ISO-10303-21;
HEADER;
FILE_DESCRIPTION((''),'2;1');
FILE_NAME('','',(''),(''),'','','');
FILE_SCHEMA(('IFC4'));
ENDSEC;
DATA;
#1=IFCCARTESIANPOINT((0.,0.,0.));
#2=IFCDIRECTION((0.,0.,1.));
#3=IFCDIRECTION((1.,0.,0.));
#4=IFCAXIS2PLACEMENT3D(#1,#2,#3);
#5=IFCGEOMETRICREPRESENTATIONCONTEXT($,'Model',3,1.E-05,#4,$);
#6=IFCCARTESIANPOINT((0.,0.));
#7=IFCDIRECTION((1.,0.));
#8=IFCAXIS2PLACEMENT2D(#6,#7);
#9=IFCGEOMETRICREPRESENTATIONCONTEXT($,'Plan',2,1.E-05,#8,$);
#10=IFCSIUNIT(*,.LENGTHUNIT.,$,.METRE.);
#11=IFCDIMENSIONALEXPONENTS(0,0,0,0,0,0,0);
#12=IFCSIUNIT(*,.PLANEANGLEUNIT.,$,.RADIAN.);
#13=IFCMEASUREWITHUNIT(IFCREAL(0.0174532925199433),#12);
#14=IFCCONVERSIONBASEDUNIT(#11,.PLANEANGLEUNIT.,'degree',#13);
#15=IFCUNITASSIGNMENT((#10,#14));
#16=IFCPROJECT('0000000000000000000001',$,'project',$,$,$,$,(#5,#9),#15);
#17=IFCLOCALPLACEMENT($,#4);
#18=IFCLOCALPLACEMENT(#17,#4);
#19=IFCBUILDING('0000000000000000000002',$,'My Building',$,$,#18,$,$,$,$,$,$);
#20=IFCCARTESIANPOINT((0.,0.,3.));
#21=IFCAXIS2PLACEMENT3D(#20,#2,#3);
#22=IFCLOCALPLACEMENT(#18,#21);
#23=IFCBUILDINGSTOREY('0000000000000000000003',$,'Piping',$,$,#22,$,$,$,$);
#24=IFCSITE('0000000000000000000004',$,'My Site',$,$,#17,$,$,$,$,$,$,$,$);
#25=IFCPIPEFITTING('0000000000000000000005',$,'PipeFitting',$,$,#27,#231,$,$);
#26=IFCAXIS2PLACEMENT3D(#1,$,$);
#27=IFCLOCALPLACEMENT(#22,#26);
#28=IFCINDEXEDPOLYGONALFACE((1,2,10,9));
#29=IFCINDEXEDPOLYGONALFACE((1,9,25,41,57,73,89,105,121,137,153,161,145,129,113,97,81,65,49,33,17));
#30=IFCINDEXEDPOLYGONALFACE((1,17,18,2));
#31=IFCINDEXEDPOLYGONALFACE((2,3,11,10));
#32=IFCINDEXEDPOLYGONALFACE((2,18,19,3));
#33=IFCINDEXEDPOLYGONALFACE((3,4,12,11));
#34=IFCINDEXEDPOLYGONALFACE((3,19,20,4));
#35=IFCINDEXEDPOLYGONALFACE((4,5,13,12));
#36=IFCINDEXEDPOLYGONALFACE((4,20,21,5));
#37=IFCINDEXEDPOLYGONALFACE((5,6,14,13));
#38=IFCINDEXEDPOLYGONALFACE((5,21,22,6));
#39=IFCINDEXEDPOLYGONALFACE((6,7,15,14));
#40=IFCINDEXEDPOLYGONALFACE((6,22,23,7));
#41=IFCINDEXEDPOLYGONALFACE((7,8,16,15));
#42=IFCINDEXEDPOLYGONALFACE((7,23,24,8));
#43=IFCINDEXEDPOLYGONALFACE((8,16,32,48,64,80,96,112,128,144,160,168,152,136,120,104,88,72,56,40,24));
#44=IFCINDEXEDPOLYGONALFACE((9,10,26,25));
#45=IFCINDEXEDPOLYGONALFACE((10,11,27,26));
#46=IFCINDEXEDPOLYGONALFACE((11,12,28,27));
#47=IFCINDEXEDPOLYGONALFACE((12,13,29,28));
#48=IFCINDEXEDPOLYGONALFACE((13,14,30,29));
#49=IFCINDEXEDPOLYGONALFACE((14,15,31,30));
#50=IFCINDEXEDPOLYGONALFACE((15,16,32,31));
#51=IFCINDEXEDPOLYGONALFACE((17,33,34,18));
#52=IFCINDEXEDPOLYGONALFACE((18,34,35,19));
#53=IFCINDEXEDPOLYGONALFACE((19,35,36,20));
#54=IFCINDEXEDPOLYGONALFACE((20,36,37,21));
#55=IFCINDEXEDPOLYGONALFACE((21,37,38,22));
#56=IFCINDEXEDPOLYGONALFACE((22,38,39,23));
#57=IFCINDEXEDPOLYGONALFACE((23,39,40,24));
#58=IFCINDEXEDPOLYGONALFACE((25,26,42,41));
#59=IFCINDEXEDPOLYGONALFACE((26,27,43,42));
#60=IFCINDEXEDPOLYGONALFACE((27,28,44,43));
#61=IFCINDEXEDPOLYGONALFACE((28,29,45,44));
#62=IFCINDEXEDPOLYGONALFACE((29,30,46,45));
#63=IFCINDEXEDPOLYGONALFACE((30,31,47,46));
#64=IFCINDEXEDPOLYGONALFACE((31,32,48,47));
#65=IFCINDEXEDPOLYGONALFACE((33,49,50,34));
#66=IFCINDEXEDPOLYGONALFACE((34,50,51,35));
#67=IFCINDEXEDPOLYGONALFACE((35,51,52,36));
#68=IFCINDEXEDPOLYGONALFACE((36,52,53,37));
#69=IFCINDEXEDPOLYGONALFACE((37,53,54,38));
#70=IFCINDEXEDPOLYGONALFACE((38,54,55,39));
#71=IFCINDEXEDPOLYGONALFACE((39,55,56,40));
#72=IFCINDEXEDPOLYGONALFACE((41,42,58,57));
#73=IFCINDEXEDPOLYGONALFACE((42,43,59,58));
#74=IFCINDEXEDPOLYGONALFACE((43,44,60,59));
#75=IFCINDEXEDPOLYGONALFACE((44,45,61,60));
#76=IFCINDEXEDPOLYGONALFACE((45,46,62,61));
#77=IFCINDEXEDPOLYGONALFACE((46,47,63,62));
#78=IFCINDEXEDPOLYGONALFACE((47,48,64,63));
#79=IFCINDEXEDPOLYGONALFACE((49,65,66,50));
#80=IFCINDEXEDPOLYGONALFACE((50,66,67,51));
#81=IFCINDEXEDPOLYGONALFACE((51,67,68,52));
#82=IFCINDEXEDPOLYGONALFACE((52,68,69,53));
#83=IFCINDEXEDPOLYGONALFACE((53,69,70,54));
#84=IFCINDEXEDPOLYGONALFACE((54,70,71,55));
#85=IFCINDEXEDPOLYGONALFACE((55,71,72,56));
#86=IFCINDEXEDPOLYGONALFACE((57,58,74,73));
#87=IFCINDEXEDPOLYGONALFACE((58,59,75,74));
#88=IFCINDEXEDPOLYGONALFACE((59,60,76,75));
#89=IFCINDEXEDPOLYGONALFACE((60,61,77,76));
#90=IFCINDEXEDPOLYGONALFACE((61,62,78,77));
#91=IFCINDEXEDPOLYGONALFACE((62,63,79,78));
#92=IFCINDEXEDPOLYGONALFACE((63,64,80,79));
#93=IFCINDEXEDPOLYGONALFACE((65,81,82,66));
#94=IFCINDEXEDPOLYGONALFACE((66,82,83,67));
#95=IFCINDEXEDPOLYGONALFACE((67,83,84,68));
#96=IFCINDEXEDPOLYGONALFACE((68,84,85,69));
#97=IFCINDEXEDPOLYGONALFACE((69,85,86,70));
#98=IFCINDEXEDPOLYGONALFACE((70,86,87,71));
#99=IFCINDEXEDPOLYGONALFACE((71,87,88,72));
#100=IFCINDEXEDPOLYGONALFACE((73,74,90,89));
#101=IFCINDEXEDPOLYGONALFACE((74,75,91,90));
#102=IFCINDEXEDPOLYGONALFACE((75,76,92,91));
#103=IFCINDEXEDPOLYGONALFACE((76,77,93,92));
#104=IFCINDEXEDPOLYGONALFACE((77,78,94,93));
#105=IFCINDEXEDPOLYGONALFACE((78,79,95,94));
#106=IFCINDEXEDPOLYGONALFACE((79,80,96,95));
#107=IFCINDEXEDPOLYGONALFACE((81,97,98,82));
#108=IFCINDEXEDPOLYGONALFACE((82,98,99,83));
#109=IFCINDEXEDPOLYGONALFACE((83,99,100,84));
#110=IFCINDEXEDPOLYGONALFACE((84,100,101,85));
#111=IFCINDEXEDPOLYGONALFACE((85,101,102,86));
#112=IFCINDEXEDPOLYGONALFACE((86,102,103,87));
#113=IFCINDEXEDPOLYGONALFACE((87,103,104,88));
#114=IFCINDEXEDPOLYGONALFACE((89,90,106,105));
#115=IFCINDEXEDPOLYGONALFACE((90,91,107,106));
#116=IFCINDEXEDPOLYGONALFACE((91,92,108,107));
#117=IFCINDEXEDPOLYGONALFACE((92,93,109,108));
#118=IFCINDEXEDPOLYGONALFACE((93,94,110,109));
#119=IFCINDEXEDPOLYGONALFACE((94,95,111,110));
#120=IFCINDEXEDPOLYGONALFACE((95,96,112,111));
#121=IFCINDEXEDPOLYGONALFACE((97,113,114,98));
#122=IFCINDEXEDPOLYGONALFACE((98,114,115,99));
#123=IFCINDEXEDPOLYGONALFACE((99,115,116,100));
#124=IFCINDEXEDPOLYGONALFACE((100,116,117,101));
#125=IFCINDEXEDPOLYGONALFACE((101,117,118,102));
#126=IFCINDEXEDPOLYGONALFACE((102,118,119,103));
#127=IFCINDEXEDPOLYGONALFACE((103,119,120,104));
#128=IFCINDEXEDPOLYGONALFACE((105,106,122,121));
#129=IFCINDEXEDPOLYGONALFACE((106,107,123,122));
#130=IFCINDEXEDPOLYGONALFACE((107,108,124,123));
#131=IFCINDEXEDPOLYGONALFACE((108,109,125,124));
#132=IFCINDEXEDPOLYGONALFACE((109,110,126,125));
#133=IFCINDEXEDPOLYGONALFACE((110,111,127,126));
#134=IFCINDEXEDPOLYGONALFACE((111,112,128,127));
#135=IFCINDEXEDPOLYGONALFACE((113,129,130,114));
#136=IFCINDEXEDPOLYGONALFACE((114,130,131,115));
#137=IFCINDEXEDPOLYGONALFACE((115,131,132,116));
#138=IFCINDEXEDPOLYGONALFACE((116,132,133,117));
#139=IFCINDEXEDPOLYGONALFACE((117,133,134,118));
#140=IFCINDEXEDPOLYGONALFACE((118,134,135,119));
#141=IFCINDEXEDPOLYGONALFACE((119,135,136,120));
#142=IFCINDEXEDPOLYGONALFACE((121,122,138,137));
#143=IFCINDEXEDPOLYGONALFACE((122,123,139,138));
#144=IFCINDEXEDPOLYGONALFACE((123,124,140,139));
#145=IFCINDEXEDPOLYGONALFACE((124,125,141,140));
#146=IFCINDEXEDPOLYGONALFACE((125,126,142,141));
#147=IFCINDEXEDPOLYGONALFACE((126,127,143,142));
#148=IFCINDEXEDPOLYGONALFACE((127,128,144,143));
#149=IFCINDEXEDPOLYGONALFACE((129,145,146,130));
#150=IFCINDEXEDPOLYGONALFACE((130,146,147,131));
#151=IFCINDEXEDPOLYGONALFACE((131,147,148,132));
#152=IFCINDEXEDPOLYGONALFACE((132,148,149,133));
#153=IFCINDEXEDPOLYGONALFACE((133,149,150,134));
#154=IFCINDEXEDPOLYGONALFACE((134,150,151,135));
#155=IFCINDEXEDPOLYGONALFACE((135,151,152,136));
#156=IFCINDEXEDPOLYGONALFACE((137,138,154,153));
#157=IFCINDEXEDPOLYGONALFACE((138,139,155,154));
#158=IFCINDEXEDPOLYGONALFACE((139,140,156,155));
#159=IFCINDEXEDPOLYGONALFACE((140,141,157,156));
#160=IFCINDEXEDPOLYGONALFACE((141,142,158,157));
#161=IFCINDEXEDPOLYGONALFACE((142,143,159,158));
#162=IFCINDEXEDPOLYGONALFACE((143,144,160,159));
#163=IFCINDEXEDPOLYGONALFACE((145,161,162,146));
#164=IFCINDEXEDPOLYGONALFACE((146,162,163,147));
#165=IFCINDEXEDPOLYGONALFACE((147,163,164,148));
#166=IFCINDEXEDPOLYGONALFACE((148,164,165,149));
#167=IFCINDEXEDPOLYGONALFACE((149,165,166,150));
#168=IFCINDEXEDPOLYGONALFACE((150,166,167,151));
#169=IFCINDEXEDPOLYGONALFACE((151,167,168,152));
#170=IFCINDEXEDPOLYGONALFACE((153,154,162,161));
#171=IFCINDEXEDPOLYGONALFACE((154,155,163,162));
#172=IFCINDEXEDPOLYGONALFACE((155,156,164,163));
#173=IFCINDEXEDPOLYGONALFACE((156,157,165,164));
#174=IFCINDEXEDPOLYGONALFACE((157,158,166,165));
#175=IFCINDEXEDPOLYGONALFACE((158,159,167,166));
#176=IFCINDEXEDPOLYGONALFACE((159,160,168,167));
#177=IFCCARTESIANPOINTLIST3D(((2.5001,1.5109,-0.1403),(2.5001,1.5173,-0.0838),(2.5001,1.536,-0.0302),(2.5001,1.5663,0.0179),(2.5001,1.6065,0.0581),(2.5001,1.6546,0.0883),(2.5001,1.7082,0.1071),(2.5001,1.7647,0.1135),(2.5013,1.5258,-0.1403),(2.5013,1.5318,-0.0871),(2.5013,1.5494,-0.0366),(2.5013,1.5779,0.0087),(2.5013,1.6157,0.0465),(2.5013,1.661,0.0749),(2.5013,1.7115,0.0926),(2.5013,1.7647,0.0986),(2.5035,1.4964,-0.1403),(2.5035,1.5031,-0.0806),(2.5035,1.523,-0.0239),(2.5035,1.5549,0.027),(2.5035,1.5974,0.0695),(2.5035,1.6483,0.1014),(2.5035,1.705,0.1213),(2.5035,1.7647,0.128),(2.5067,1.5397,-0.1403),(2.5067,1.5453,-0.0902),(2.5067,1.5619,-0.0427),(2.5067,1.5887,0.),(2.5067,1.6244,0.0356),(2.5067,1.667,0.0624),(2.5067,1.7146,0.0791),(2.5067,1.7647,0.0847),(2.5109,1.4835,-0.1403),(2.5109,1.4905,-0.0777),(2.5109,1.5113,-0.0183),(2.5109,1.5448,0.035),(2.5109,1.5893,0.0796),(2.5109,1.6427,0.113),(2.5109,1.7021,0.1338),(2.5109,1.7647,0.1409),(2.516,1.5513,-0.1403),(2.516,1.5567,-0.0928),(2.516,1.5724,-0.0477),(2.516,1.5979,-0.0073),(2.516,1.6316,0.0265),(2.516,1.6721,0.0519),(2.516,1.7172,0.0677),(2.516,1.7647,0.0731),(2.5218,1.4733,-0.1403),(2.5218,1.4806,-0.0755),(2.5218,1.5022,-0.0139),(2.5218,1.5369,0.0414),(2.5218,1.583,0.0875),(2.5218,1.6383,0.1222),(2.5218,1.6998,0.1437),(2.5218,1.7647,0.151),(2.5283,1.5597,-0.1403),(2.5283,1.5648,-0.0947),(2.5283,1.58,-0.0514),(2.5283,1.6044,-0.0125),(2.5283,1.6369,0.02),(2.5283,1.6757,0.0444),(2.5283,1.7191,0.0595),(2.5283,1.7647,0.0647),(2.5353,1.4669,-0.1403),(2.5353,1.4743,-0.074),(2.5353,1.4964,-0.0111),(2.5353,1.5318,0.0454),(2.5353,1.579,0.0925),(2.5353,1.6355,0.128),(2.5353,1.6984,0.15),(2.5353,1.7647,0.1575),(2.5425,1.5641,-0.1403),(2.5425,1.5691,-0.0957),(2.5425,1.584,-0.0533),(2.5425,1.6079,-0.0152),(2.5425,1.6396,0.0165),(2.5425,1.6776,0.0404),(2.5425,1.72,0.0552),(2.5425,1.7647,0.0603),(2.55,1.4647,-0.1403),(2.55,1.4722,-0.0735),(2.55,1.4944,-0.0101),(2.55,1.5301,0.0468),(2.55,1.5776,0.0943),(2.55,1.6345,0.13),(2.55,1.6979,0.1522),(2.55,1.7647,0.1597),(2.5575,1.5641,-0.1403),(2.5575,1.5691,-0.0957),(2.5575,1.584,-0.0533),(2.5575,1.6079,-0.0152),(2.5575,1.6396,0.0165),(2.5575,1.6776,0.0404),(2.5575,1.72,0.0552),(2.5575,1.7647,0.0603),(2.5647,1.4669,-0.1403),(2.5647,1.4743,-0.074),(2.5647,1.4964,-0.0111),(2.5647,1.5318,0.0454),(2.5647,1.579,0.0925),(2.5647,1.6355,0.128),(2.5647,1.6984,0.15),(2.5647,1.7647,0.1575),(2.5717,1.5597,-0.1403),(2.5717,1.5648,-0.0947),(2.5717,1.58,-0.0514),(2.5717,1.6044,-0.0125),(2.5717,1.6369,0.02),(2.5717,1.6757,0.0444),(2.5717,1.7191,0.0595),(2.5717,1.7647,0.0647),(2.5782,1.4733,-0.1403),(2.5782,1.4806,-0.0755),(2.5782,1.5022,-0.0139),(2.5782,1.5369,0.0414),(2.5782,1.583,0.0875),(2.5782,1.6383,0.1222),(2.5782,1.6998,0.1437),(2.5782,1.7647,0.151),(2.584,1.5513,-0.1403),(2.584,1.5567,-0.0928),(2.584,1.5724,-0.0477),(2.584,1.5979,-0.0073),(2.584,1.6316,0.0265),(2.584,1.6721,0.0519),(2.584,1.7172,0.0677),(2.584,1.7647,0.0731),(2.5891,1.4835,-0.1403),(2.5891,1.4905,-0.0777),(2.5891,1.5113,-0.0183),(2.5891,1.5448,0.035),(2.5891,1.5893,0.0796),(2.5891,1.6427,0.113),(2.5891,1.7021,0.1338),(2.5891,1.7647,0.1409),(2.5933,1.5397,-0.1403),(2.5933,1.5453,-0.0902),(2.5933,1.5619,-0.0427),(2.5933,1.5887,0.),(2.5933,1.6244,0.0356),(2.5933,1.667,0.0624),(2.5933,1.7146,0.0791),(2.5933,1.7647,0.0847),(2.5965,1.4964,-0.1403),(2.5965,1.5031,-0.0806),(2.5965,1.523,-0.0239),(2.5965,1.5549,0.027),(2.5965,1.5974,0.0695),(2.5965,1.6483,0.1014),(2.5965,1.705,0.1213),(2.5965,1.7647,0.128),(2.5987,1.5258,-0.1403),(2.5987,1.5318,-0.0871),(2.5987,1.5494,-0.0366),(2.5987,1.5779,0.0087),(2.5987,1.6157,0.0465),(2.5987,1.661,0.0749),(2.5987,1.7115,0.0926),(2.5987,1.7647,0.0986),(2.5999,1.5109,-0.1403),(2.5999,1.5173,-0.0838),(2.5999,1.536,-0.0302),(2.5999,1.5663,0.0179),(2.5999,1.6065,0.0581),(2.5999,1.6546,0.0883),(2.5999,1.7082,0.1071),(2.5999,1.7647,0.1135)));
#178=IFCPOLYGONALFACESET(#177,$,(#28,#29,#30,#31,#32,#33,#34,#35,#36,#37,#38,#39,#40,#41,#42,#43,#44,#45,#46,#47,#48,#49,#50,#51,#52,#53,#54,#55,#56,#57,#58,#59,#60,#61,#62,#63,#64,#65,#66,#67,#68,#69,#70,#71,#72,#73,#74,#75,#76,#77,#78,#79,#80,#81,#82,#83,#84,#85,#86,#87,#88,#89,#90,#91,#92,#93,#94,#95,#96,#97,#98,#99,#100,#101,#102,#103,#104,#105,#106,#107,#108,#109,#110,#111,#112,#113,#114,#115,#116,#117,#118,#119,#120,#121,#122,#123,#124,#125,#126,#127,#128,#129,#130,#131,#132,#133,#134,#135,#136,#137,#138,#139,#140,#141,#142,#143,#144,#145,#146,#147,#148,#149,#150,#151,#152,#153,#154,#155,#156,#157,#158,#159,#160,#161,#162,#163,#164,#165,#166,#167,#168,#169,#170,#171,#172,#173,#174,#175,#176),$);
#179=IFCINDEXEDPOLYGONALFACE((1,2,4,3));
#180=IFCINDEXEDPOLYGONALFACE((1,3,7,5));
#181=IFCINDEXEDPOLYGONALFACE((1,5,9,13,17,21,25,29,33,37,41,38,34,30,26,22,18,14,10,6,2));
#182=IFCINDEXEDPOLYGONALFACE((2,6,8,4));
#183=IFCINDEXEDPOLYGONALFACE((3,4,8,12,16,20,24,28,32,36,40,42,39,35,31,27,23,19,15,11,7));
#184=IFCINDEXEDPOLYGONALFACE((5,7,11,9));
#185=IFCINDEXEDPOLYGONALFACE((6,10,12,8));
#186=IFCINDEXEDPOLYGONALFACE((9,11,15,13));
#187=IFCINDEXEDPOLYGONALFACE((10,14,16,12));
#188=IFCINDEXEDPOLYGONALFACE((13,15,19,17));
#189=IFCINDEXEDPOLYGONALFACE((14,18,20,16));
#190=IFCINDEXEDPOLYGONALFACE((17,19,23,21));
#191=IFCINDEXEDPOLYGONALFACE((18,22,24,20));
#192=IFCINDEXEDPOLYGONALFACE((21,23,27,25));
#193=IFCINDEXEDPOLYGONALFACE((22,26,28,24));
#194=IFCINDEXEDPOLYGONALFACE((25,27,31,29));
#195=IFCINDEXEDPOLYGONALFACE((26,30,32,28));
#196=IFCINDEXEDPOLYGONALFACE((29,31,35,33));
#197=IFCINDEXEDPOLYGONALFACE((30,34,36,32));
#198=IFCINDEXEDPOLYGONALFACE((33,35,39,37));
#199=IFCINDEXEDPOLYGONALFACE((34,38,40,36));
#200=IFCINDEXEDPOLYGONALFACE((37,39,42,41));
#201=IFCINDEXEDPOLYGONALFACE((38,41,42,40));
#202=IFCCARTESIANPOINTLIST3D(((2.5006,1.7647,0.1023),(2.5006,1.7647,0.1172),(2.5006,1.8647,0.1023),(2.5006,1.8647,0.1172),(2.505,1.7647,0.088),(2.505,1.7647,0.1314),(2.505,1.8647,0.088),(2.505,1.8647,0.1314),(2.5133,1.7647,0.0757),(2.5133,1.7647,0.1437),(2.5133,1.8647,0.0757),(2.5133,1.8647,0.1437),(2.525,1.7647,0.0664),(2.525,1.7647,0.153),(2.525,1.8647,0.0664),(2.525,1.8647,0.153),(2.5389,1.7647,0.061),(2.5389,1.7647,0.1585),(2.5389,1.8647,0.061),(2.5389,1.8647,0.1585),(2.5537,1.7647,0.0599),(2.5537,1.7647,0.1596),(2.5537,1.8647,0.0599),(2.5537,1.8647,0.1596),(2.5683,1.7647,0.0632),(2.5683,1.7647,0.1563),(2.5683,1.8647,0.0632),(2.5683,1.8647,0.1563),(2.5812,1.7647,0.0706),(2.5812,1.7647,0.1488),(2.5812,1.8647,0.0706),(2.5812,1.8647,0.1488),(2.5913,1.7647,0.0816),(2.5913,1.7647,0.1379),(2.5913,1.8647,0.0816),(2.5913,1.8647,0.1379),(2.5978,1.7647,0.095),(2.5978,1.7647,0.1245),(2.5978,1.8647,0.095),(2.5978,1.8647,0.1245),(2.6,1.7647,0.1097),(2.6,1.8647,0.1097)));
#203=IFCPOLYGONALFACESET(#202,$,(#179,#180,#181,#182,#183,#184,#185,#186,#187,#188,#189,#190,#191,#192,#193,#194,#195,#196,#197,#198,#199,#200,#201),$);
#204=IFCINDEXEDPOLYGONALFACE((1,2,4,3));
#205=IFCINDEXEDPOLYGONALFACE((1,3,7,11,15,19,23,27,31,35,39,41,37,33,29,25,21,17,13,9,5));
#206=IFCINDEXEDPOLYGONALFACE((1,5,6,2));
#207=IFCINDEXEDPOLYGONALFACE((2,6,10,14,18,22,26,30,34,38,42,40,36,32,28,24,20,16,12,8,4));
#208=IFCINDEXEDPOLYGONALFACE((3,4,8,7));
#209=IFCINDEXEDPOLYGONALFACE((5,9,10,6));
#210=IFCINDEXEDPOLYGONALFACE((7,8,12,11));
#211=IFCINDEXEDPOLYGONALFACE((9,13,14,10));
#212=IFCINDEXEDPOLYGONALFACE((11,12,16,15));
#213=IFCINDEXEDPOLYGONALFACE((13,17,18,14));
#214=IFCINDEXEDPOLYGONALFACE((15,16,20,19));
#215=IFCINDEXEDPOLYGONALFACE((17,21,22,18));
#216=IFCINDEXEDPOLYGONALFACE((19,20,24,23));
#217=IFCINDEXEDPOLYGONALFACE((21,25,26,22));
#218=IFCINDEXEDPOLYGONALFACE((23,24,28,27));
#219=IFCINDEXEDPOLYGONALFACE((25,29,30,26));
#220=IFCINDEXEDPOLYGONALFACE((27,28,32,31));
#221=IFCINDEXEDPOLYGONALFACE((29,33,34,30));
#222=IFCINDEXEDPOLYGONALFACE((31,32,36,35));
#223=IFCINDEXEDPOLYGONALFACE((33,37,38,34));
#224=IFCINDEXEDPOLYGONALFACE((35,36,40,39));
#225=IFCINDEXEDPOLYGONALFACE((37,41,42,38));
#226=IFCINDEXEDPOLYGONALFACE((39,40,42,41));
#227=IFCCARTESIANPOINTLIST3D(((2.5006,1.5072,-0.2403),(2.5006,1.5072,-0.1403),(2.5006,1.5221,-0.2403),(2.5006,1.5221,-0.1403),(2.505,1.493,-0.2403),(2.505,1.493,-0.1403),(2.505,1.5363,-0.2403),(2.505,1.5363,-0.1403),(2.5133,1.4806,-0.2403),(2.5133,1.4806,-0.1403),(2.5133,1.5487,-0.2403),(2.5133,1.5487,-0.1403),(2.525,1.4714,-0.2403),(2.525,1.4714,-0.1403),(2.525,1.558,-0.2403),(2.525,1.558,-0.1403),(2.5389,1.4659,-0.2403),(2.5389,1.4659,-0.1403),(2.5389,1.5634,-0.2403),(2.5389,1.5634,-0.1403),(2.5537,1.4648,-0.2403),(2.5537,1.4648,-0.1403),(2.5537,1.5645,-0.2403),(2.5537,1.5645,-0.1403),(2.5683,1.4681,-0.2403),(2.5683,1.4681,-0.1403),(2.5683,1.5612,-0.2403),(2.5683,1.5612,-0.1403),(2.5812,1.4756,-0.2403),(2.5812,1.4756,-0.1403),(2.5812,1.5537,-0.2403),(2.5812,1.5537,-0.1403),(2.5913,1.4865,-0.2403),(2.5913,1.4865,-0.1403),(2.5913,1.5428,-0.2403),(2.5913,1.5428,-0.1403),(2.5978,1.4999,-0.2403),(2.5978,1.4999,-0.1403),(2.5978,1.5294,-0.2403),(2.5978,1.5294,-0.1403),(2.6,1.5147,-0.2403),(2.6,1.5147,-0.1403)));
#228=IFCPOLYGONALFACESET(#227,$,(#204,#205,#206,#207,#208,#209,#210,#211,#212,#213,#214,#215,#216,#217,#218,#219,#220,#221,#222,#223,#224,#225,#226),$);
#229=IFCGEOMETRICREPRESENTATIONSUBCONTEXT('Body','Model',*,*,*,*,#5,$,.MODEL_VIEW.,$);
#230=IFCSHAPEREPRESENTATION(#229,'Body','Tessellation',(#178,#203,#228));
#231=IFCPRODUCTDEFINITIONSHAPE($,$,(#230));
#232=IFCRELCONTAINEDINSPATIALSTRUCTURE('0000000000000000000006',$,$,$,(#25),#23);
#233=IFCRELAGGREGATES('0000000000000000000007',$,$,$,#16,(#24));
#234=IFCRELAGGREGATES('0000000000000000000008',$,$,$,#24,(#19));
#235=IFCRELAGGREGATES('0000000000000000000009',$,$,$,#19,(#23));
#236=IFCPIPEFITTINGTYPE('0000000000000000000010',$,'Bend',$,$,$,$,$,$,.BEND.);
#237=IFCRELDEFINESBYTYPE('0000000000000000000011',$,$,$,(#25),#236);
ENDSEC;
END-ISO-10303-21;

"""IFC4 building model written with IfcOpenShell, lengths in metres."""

from ifc_helpers import new_model, entity, si_unit, converted_unit, frame, origin_with_axes, origin_2d_with_axis, place, context, subcontext, project, spatial, circle, extrude, source, transform, mapped, type_object, type_shapes, element, save


model = new_model("IFC4")

# Units and contexts
model_context = context("Model", 3, precision=1e-05, world=origin_with_axes())
plan_context = context("Plan", 2, precision=1e-05, world=origin_2d_with_axis())
body_context = subcontext(model_context, "Body", "Model", "MODEL_VIEW")
ifc_project = project(units=[si_unit("LENGTHUNIT", "METRE"), converted_unit("PLANEANGLEUNIT", "degree", entity("IfcReal", 0.0174532925199433), si_unit("PLANEANGLEUNIT", "RADIAN"), dimensions=[0, 0, 0, 0, 0, 0, 0])], contexts=[model_context, plan_context])

# Site, building, storey
site_placement = place(None, origin_with_axes())
site = spatial("IfcSite", under=ifc_project, at=site_placement, Name="My Site")
building_placement = place(site_placement, origin_with_axes())
building = spatial("IfcBuilding", under=site, at=building_placement, Name="My Building")
storey_placement = place(building_placement, frame((0.0, 0.0, 3.0), z_axis=(0.0, 0.0, 1.0), x_axis=(1.0, 0.0, 0.0)))
storey = spatial("IfcBuildingStorey", under=building, at=storey_placement, Name="Piping")

# Pipe fitting
pipe_fitting_type_1 = type_object("IfcPipeFittingType", Name="Bend", PredefinedType="BEND")
shared_shape_1 = source(origin_with_axes(), body_context, "Body", "SolidModel", [
    entity("IfcSweptDiskSolid", entity("IfcIndexedPolyCurve", entity("IfcCartesianPointList3D", [[0.0, 0.0, 0.1], [0.0, -0.0732, 0.2768], [0.0, -0.25, 0.35]]), [entity("IfcArcIndex", [1, 2, 3])]), 0.05),
    extrude(circle(Radius=0.05), origin_with_axes(), (0.0, 0.0, 1.0), 0.1),
    extrude(circle(Radius=0.05), frame((0.0, -0.25, 0.35), z_axis=(0.0, -1.0, -0.000021), x_axis=(1.0, 0.0, 0.0)), (0.0, 0.0, 1.0), 0.1),
])
type_shapes(pipe_fitting_type_1, [shared_shape_1])
for number, where, z_axis, x_axis, name in (
    (1, (2.55, 1.8647, 0.1097), (0.0, -1.0, 0.000021), (1.0, 0.0, 0.0), "PipeFitting"),
):
    element("IfcPipeFitting", number, at=place(storey_placement, frame(where, z_axis=z_axis, x_axis=x_axis)), inside=storey, type_object=pipe_fitting_type_1, Name=name, context=body_context, shape_type="MappedRepresentation", body=[
        mapped(shared_shape_1, transform((0.0, 0.0, 0.0), x_axis=(1.0, 0.0, 0.0), y_axis=(0.0, 1.0, 0.0), z_axis=(0.0, 0.0, 1.0), scale=1.0)),
    ])

save(model, "model.ifc")
